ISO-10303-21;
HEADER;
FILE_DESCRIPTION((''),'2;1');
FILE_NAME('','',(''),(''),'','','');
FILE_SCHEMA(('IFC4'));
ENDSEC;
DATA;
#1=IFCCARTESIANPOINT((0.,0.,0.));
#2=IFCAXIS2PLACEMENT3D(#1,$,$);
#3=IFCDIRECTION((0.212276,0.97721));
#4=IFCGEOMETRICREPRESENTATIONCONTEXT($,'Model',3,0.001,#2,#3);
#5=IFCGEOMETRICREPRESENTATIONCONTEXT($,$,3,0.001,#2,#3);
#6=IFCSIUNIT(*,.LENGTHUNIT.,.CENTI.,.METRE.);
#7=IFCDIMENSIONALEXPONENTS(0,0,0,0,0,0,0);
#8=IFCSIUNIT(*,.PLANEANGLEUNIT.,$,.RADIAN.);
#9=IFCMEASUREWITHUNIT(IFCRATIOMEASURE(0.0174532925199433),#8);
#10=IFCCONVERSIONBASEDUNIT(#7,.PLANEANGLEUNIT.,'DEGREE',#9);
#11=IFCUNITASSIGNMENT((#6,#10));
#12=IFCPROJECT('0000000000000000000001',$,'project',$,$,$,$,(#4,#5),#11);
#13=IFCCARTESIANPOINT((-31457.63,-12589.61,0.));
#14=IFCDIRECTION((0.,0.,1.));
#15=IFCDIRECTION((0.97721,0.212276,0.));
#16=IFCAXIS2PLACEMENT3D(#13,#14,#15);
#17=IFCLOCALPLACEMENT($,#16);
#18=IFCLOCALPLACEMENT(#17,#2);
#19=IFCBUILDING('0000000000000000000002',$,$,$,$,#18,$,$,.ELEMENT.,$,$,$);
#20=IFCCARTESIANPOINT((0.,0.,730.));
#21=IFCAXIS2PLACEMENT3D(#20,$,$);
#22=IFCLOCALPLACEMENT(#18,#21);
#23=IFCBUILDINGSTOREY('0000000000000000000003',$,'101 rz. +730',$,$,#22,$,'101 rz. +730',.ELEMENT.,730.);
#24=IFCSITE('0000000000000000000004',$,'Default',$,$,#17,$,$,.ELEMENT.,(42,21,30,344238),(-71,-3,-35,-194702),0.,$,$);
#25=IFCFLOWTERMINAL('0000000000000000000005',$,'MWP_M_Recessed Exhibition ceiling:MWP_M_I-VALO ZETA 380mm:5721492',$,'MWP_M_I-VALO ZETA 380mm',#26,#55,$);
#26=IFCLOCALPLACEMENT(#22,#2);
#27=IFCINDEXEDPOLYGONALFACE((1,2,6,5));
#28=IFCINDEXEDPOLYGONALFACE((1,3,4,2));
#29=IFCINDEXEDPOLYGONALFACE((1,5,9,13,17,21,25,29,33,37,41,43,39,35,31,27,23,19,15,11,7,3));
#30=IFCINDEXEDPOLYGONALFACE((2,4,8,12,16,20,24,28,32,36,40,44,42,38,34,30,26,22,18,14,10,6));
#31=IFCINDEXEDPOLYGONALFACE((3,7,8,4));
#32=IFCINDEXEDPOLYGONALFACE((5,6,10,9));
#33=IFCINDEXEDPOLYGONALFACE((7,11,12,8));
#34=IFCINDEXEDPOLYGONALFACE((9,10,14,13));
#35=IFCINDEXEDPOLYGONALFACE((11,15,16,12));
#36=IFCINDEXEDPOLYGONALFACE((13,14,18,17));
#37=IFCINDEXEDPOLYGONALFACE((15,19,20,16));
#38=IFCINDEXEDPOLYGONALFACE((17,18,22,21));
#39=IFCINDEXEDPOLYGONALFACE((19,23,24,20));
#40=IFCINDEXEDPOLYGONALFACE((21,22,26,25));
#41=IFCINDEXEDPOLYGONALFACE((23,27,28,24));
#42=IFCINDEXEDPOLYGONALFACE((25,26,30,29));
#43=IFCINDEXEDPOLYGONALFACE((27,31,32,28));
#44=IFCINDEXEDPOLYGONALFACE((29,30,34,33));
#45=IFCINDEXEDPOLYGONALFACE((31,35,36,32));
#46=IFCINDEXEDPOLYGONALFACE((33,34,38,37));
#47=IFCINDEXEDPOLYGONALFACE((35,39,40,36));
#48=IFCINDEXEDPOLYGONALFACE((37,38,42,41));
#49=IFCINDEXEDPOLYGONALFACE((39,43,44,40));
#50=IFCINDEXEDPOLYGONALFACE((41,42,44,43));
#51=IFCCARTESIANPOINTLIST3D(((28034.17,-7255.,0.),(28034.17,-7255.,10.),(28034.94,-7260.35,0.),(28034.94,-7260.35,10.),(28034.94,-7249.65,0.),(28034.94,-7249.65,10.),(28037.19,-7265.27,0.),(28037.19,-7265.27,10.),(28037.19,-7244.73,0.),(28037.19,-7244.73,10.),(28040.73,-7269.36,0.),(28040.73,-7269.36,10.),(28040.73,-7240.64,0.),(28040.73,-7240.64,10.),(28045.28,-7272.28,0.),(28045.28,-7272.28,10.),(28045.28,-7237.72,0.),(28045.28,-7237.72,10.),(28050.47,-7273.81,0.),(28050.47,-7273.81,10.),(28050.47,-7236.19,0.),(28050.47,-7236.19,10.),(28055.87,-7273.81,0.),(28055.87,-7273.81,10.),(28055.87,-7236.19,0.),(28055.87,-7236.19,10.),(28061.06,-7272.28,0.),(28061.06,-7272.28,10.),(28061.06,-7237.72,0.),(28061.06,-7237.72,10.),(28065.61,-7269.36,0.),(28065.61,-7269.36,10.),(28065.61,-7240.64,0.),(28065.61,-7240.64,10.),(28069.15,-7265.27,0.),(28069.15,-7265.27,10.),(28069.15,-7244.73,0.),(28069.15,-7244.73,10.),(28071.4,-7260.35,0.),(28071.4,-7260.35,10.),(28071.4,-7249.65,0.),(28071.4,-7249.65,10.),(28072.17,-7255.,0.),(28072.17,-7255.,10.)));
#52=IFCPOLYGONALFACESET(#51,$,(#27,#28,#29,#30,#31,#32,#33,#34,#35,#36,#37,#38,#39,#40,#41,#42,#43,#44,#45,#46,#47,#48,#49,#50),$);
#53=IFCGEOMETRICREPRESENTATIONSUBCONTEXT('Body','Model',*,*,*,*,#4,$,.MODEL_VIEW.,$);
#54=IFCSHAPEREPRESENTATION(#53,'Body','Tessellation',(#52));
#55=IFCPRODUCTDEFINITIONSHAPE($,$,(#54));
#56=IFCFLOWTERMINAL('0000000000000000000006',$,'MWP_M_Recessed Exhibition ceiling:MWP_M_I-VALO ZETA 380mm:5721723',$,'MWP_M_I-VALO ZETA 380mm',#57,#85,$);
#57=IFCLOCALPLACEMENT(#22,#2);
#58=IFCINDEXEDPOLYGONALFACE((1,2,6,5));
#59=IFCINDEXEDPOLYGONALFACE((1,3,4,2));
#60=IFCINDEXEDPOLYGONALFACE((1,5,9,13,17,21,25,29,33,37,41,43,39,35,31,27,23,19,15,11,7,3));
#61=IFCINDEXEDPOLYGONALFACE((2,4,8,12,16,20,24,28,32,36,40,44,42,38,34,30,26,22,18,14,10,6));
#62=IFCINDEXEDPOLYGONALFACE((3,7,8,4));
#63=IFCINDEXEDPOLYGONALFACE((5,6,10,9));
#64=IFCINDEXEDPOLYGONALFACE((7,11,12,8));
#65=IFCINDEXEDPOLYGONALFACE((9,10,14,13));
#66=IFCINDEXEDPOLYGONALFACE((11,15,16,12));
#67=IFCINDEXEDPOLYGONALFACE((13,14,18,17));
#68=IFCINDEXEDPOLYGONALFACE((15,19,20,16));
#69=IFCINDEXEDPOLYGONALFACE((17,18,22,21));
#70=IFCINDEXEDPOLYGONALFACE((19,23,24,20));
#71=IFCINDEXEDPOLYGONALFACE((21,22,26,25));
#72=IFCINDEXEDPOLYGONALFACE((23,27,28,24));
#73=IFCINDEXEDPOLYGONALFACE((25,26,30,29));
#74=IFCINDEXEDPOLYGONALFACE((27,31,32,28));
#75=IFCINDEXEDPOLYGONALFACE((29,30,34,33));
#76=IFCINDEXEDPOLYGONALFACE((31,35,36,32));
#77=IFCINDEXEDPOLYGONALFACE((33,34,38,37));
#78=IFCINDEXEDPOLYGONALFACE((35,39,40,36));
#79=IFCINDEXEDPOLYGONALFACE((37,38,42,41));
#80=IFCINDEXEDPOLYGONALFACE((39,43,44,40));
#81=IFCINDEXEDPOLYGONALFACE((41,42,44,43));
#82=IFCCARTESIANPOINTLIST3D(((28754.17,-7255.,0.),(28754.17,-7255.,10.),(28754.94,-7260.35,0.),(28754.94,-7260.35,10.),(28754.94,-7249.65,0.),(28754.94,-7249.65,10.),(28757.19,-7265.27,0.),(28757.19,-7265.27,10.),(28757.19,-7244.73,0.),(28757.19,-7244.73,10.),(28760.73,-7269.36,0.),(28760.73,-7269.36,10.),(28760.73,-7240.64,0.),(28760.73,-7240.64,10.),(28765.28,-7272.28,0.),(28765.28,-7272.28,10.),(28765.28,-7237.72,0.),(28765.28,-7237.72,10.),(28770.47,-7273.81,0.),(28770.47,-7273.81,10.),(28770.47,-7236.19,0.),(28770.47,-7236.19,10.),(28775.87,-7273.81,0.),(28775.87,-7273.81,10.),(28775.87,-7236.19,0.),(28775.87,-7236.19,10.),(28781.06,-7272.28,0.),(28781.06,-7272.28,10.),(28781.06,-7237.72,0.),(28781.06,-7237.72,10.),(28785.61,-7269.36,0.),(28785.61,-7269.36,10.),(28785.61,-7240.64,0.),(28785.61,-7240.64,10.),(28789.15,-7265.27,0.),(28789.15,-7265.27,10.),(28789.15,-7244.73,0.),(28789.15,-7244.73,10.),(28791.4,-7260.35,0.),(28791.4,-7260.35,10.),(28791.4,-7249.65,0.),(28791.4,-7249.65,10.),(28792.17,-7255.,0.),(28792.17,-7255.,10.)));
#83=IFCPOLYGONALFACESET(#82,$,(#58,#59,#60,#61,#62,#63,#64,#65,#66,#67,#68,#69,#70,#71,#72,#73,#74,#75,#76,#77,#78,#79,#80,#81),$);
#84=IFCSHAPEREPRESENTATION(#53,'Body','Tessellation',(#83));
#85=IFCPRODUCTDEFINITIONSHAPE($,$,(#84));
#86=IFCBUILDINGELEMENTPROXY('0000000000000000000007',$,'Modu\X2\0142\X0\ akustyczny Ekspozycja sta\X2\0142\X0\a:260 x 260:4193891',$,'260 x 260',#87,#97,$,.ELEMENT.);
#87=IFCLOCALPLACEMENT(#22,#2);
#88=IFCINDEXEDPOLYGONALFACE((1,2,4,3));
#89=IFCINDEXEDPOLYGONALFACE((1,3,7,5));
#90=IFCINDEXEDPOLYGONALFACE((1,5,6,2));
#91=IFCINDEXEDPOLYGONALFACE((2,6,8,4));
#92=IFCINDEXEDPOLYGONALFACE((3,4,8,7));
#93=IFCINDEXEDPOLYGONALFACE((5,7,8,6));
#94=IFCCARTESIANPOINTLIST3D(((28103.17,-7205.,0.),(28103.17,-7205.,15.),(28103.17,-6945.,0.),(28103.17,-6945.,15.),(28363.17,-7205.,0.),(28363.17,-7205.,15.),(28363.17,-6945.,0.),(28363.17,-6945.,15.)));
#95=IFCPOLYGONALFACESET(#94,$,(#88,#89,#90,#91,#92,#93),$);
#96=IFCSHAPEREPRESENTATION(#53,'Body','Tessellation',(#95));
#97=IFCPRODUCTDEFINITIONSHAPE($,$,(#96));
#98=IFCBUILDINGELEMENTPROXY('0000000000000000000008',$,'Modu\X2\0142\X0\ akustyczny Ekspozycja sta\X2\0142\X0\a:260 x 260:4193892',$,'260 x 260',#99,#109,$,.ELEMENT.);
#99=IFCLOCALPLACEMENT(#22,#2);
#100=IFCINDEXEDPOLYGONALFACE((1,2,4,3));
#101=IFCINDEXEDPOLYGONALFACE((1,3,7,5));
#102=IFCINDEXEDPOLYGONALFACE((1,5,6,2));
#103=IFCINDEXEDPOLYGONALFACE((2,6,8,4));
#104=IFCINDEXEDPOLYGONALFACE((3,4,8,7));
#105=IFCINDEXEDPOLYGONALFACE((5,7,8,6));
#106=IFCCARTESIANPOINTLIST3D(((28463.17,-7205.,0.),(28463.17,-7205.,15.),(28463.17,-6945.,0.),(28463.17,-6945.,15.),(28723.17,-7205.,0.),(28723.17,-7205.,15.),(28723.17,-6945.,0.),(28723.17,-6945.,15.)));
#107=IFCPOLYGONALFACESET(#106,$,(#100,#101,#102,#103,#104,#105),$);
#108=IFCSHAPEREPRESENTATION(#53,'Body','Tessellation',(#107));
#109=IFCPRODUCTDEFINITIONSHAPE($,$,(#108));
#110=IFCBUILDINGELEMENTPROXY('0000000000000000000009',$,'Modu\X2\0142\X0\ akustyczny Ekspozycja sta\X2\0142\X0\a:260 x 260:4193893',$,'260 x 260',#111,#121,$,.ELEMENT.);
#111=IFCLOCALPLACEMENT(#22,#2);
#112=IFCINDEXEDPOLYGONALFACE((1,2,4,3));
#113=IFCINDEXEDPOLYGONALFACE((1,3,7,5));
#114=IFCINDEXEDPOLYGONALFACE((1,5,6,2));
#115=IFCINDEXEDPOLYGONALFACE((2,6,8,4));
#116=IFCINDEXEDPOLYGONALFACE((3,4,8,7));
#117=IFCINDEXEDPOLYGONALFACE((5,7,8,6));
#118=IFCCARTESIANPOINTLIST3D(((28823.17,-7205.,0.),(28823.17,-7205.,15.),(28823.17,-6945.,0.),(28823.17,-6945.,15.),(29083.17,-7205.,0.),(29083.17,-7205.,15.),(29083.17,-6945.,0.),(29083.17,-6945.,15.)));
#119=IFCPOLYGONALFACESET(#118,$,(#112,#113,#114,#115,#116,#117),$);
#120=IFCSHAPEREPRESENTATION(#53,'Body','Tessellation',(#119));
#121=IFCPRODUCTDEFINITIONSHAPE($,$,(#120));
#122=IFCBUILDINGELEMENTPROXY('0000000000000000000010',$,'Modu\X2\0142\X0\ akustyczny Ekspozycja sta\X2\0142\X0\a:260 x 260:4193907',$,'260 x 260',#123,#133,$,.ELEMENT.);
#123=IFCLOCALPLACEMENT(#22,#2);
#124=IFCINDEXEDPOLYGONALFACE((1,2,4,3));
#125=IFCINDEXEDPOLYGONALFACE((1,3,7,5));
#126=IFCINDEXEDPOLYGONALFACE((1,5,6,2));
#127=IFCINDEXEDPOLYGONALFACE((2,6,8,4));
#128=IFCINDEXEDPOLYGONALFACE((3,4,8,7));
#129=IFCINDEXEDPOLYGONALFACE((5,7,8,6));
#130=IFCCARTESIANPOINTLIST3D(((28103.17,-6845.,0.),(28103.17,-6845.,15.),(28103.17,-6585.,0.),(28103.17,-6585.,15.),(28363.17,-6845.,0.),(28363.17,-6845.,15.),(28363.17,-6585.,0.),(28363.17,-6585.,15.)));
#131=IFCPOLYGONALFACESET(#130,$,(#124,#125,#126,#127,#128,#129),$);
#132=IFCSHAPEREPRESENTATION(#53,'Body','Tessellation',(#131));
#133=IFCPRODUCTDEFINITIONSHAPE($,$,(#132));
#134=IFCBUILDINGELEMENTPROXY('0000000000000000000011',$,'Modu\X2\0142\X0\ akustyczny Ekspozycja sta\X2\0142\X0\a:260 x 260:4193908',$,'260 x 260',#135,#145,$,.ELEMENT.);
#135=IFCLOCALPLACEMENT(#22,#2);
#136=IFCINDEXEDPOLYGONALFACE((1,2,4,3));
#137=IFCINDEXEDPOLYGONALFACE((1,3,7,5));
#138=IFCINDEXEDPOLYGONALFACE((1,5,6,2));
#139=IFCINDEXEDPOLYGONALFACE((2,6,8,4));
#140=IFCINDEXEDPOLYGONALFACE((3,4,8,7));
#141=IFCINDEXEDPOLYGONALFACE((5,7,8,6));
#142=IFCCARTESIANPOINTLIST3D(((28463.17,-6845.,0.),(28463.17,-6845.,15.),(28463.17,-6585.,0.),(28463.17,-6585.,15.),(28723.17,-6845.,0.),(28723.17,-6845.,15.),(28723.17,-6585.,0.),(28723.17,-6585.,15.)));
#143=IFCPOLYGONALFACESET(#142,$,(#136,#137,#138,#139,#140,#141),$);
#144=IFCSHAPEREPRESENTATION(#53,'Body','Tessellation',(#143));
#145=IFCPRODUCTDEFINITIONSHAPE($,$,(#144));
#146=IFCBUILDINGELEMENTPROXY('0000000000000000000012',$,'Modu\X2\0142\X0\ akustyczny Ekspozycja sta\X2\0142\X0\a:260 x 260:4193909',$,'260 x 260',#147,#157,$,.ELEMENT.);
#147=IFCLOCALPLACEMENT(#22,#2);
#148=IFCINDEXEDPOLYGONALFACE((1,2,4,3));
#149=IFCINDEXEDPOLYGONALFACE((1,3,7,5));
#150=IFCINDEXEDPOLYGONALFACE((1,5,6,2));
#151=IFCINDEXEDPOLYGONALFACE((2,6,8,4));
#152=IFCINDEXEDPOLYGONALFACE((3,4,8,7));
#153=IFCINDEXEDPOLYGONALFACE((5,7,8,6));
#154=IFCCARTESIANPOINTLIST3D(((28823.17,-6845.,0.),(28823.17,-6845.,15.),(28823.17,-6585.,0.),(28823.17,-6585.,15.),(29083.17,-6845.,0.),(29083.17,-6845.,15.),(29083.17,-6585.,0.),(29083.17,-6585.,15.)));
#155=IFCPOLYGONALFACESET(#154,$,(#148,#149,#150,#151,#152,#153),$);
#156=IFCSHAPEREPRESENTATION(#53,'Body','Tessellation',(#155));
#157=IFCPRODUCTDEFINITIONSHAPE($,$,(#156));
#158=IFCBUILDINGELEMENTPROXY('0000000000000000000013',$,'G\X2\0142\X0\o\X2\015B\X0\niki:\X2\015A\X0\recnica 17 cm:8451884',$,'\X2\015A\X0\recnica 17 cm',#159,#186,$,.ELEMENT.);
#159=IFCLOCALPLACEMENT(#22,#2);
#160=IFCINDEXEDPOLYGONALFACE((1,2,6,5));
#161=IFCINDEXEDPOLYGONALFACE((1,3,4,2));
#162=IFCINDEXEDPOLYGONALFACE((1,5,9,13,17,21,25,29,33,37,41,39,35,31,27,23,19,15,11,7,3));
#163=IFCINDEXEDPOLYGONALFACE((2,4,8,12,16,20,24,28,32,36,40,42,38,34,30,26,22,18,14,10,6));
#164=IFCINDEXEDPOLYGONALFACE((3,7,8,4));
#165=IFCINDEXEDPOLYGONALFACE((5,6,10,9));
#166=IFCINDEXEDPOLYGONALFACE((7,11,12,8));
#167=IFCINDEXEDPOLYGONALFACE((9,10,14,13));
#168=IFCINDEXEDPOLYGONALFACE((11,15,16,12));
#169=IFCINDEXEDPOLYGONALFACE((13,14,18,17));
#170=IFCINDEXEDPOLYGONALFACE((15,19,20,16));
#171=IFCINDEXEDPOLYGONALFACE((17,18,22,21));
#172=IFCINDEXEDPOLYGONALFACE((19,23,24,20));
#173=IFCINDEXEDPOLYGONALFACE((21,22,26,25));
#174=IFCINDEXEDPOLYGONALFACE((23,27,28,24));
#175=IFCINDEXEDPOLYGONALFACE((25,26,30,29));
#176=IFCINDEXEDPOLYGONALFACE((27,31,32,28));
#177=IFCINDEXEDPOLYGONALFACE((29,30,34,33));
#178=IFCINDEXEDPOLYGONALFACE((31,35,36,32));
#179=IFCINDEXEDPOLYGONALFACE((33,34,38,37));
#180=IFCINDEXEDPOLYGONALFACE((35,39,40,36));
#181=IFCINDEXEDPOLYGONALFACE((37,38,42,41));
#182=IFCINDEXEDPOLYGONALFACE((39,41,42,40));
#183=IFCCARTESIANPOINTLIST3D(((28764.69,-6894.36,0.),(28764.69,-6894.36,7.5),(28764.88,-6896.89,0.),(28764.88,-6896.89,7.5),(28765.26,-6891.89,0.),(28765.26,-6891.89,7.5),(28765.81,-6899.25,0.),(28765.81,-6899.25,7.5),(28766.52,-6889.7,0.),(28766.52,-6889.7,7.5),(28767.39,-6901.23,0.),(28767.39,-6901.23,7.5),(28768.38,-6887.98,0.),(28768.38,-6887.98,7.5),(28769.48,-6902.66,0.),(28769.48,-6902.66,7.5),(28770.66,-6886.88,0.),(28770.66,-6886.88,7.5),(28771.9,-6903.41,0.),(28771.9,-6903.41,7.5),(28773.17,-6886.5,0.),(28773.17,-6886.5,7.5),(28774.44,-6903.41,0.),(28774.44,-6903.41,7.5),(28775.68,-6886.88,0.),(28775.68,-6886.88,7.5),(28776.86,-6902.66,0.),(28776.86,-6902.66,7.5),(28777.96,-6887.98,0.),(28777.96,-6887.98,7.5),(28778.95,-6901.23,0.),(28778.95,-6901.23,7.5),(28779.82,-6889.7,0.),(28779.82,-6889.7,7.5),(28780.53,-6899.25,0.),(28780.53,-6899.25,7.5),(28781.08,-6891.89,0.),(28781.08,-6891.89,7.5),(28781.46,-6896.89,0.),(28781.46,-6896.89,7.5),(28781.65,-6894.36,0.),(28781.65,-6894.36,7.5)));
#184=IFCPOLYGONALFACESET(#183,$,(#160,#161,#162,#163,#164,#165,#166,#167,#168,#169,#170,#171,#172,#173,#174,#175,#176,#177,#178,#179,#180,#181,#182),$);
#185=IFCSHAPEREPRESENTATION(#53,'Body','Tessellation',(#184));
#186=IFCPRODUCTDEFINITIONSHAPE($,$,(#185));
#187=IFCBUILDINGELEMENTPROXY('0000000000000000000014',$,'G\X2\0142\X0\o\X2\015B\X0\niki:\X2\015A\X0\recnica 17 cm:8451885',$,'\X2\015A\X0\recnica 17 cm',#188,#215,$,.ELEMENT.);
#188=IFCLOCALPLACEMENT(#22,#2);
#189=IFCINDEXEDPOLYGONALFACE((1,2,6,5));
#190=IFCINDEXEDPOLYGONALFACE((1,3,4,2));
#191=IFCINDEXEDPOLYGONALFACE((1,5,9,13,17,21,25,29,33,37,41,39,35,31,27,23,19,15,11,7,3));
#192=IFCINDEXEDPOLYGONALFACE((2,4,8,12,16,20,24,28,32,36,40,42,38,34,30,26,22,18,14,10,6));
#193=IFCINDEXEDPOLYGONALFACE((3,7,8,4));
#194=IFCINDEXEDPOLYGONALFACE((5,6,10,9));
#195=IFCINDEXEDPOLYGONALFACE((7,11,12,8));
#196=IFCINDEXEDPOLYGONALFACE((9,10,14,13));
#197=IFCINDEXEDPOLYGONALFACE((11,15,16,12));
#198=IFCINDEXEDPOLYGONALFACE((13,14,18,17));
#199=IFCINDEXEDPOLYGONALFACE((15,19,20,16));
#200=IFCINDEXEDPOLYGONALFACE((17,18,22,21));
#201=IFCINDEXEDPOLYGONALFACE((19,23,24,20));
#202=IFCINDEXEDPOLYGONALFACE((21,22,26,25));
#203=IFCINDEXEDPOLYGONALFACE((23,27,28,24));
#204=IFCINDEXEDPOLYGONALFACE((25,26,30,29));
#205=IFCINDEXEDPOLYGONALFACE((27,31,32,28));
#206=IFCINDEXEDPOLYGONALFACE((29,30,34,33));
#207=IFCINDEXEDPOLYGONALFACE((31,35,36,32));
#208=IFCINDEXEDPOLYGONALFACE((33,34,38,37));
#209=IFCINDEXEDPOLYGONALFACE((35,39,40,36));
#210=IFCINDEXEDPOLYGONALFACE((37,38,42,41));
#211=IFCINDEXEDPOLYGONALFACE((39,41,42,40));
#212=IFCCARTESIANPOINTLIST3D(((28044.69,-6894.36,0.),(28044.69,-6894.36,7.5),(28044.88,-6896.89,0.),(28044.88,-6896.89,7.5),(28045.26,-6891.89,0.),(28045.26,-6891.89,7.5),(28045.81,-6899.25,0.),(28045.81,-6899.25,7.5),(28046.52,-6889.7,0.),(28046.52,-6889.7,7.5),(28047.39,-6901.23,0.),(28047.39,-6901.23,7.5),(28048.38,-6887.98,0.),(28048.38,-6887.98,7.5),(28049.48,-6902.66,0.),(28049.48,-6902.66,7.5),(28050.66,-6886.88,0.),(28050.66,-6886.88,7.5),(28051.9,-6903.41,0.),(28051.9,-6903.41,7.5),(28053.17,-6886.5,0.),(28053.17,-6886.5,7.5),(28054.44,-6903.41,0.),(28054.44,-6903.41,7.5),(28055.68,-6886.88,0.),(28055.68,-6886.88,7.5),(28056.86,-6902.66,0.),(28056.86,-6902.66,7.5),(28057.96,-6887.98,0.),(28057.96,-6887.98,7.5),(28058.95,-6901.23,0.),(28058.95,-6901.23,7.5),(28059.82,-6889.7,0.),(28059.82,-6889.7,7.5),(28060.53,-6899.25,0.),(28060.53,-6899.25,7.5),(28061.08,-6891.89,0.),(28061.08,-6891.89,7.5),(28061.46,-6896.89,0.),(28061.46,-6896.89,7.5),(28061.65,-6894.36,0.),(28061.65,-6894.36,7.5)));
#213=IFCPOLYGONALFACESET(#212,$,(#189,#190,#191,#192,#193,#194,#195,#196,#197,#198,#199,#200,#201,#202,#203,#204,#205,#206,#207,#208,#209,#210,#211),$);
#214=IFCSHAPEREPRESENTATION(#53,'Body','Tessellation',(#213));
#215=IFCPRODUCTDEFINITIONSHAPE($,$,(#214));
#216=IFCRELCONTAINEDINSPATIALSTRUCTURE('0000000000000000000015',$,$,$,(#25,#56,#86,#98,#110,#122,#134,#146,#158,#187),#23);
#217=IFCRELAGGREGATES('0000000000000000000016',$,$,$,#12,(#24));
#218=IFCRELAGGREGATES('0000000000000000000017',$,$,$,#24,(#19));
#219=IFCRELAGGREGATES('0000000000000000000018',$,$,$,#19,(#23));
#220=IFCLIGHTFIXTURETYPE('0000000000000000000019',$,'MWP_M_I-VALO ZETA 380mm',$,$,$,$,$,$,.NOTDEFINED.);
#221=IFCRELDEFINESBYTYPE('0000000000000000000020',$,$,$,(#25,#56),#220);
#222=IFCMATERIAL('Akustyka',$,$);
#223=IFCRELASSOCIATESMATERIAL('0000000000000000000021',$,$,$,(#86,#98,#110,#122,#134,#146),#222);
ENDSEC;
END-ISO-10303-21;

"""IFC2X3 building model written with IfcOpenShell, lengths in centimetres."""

from ifc_helpers import new_model, entity, si_unit, converted_unit, direction, frame, frame_2d, origin, origin_2d_with_axis, place, context, subcontext, project, spatial, rectangle, circle, extrude, source, transform, mapped, material, type_object, type_shapes, element, save


model = new_model("IFC2X3")

# Units and contexts
model_context = context("Model", 3, precision=0.001, world=origin(), true_north=direction((0.212276, 0.97721)))
context_of_model = context(None, 3, precision=0.001, world=origin(), true_north=direction((0.212276, 0.97721)))
body_context = subcontext(model_context, "Body", "Model", "MODEL_VIEW")
ifc_project = project(units=[si_unit("LENGTHUNIT", "METRE", prefix="CENTI"), converted_unit("PLANEANGLEUNIT", "DEGREE", entity("IfcRatioMeasure", 0.0174532925199433), si_unit("PLANEANGLEUNIT", "RADIAN"), dimensions=[0, 0, 0, 0, 0, 0, 0])], contexts=[model_context, context_of_model])

# Site, building, storey
site_placement = place(None, frame((-31457.63, -12589.61, 0.0), z_axis=(0.0, 0.0, 1.0), x_axis=(0.97721, 0.212276, 0.0)))
site = spatial("IfcSite", under=ifc_project, at=site_placement, Name="Default", CompositionType="ELEMENT", RefLatitude=(42, 21, 30, 344238), RefLongitude=(-71, -3, -35, -194702), RefElevation=0.0)
building_placement = place(site_placement, origin())
building = spatial("IfcBuilding", under=site, at=building_placement, CompositionType="ELEMENT")
storey_placement = place(building_placement, frame((0.0, 0.0, 730.0)))
storey = spatial("IfcBuildingStorey", under=building, at=storey_placement, Name="101 rz. +730", LongName="101 rz. +730", CompositionType="ELEMENT", Elevation=730.0)

# Flow terminals
light_fixture_type_1 = type_object("IfcLightFixtureType", Name="MWP_M_I-VALO ZETA 380mm", PredefinedType="NOTDEFINED")
shared_shape_1 = source(origin(), body_context, "Body", "SweptSolid", [
    extrude(circle(Radius=19.0, at=frame_2d((0.0, 0.0), x_axis=(1.0, 0.0))), frame((0.0, 0.0, -10.0)), (0.0, 0.0, 1.0), 10.0),
])
type_shapes(light_fixture_type_1, [shared_shape_1])
for number, where, z_axis, x_axis, name in (
    (1, (28053.17, -7255.0, 0.0), (0.0, 0.0, -1.0), (1.0, 0.0, 0.0), "MWP_M_Recessed Exhibition ceiling:MWP_M_I-VALO ZETA 380mm:5721492"),
    (2, (28773.17, -7255.0, 0.0), (0.0, 0.0, -1.0), (1.0, 0.0, 0.0), "MWP_M_Recessed Exhibition ceiling:MWP_M_I-VALO ZETA 380mm:5721723"),
):
    element("IfcFlowTerminal", number, at=place(storey_placement, frame(where, z_axis=z_axis, x_axis=x_axis)), inside=storey, type_object=light_fixture_type_1, Name=name, ObjectType="MWP_M_I-VALO ZETA 380mm", context=body_context, shape_type="MappedRepresentation", body=[
        mapped(shared_shape_1, transform((0.0, 0.0, 0.0), scale=1.0)),
    ])

# Building element proxies
ifc_material_1 = material(Name="Akustyka")
shared_shape_2 = source(origin(), body_context, "Body", "SweptSolid", [
    extrude(rectangle(XDim=260.0, YDim=260.0, at=origin_2d_with_axis()), frame((0.0, 0.0, -15.0), z_axis=(0.0, 0.0, 1.0), x_axis=(-1.0, 0.0, 0.0)), (0.0, 0.0, 1.0), 15.0),
])
for number, where, z_axis, x_axis, name in (
    (3, (28233.17, -7075.0, 0.0), (0.0, 0.0, -1.0), (1.0, 0.0, 0.0), "Moduł akustyczny Ekspozycja stała:260 x 260:4193891"),
    (4, (28593.17, -7075.0, 0.0), (0.0, 0.0, -1.0), (1.0, 0.0, 0.0), "Moduł akustyczny Ekspozycja stała:260 x 260:4193892"),
    (5, (28953.17, -7075.0, 0.0), (0.0, 0.0, -1.0), (1.0, 0.0, 0.0), "Moduł akustyczny Ekspozycja stała:260 x 260:4193893"),
    (6, (28233.17, -6715.0, 0.0), (0.0, 0.0, -1.0), (1.0, 0.0, 0.0), "Moduł akustyczny Ekspozycja stała:260 x 260:4193907"),
    (7, (28593.17, -6715.0, 0.0), (0.0, 0.0, -1.0), (1.0, 0.0, 0.0), "Moduł akustyczny Ekspozycja stała:260 x 260:4193908"),
    (8, (28953.17, -6715.0, 0.0), (0.0, 0.0, -1.0), (1.0, 0.0, 0.0), "Moduł akustyczny Ekspozycja stała:260 x 260:4193909"),
):
    element("IfcBuildingElementProxy", number, at=place(storey_placement, frame(where, z_axis=z_axis, x_axis=x_axis)), inside=storey, material=ifc_material_1, Name=name, ObjectType="260 x 260", CompositionType="ELEMENT", context=body_context, shape_type="MappedRepresentation", body=[
        mapped(shared_shape_2, transform((0.0, 0.0, 0.0), scale=1.0)),
    ])
shared_shape_3 = source(origin(), body_context, "Body", "SweptSolid", [
    extrude(circle(Radius=8.5, at=frame_2d((0.0, 0.0), x_axis=(1.0, 0.0))), frame((0.0, 0.0, 0.0), z_axis=(0.0, 0.0, 1.0), x_axis=(0.0, 1.0, 0.0)), (0.0, 0.0, 1.0), 7.5),
])
for number, where, name in (
    (9, (28773.17, -6895.0, 0.0), "Głośniki:Śrecnica 17 cm:8451884"),
    (10, (28053.17, -6895.0, 0.0), "Głośniki:Śrecnica 17 cm:8451885"),
):
    element("IfcBuildingElementProxy", number, at=place(storey_placement, frame(where)), inside=storey, Name=name, ObjectType="Śrecnica 17 cm", CompositionType="ELEMENT", context=body_context, shape_type="MappedRepresentation", body=[
        mapped(shared_shape_3, transform((0.0, 0.0, 0.0), scale=1.0)),
    ])

save(model, "model.ifc")
